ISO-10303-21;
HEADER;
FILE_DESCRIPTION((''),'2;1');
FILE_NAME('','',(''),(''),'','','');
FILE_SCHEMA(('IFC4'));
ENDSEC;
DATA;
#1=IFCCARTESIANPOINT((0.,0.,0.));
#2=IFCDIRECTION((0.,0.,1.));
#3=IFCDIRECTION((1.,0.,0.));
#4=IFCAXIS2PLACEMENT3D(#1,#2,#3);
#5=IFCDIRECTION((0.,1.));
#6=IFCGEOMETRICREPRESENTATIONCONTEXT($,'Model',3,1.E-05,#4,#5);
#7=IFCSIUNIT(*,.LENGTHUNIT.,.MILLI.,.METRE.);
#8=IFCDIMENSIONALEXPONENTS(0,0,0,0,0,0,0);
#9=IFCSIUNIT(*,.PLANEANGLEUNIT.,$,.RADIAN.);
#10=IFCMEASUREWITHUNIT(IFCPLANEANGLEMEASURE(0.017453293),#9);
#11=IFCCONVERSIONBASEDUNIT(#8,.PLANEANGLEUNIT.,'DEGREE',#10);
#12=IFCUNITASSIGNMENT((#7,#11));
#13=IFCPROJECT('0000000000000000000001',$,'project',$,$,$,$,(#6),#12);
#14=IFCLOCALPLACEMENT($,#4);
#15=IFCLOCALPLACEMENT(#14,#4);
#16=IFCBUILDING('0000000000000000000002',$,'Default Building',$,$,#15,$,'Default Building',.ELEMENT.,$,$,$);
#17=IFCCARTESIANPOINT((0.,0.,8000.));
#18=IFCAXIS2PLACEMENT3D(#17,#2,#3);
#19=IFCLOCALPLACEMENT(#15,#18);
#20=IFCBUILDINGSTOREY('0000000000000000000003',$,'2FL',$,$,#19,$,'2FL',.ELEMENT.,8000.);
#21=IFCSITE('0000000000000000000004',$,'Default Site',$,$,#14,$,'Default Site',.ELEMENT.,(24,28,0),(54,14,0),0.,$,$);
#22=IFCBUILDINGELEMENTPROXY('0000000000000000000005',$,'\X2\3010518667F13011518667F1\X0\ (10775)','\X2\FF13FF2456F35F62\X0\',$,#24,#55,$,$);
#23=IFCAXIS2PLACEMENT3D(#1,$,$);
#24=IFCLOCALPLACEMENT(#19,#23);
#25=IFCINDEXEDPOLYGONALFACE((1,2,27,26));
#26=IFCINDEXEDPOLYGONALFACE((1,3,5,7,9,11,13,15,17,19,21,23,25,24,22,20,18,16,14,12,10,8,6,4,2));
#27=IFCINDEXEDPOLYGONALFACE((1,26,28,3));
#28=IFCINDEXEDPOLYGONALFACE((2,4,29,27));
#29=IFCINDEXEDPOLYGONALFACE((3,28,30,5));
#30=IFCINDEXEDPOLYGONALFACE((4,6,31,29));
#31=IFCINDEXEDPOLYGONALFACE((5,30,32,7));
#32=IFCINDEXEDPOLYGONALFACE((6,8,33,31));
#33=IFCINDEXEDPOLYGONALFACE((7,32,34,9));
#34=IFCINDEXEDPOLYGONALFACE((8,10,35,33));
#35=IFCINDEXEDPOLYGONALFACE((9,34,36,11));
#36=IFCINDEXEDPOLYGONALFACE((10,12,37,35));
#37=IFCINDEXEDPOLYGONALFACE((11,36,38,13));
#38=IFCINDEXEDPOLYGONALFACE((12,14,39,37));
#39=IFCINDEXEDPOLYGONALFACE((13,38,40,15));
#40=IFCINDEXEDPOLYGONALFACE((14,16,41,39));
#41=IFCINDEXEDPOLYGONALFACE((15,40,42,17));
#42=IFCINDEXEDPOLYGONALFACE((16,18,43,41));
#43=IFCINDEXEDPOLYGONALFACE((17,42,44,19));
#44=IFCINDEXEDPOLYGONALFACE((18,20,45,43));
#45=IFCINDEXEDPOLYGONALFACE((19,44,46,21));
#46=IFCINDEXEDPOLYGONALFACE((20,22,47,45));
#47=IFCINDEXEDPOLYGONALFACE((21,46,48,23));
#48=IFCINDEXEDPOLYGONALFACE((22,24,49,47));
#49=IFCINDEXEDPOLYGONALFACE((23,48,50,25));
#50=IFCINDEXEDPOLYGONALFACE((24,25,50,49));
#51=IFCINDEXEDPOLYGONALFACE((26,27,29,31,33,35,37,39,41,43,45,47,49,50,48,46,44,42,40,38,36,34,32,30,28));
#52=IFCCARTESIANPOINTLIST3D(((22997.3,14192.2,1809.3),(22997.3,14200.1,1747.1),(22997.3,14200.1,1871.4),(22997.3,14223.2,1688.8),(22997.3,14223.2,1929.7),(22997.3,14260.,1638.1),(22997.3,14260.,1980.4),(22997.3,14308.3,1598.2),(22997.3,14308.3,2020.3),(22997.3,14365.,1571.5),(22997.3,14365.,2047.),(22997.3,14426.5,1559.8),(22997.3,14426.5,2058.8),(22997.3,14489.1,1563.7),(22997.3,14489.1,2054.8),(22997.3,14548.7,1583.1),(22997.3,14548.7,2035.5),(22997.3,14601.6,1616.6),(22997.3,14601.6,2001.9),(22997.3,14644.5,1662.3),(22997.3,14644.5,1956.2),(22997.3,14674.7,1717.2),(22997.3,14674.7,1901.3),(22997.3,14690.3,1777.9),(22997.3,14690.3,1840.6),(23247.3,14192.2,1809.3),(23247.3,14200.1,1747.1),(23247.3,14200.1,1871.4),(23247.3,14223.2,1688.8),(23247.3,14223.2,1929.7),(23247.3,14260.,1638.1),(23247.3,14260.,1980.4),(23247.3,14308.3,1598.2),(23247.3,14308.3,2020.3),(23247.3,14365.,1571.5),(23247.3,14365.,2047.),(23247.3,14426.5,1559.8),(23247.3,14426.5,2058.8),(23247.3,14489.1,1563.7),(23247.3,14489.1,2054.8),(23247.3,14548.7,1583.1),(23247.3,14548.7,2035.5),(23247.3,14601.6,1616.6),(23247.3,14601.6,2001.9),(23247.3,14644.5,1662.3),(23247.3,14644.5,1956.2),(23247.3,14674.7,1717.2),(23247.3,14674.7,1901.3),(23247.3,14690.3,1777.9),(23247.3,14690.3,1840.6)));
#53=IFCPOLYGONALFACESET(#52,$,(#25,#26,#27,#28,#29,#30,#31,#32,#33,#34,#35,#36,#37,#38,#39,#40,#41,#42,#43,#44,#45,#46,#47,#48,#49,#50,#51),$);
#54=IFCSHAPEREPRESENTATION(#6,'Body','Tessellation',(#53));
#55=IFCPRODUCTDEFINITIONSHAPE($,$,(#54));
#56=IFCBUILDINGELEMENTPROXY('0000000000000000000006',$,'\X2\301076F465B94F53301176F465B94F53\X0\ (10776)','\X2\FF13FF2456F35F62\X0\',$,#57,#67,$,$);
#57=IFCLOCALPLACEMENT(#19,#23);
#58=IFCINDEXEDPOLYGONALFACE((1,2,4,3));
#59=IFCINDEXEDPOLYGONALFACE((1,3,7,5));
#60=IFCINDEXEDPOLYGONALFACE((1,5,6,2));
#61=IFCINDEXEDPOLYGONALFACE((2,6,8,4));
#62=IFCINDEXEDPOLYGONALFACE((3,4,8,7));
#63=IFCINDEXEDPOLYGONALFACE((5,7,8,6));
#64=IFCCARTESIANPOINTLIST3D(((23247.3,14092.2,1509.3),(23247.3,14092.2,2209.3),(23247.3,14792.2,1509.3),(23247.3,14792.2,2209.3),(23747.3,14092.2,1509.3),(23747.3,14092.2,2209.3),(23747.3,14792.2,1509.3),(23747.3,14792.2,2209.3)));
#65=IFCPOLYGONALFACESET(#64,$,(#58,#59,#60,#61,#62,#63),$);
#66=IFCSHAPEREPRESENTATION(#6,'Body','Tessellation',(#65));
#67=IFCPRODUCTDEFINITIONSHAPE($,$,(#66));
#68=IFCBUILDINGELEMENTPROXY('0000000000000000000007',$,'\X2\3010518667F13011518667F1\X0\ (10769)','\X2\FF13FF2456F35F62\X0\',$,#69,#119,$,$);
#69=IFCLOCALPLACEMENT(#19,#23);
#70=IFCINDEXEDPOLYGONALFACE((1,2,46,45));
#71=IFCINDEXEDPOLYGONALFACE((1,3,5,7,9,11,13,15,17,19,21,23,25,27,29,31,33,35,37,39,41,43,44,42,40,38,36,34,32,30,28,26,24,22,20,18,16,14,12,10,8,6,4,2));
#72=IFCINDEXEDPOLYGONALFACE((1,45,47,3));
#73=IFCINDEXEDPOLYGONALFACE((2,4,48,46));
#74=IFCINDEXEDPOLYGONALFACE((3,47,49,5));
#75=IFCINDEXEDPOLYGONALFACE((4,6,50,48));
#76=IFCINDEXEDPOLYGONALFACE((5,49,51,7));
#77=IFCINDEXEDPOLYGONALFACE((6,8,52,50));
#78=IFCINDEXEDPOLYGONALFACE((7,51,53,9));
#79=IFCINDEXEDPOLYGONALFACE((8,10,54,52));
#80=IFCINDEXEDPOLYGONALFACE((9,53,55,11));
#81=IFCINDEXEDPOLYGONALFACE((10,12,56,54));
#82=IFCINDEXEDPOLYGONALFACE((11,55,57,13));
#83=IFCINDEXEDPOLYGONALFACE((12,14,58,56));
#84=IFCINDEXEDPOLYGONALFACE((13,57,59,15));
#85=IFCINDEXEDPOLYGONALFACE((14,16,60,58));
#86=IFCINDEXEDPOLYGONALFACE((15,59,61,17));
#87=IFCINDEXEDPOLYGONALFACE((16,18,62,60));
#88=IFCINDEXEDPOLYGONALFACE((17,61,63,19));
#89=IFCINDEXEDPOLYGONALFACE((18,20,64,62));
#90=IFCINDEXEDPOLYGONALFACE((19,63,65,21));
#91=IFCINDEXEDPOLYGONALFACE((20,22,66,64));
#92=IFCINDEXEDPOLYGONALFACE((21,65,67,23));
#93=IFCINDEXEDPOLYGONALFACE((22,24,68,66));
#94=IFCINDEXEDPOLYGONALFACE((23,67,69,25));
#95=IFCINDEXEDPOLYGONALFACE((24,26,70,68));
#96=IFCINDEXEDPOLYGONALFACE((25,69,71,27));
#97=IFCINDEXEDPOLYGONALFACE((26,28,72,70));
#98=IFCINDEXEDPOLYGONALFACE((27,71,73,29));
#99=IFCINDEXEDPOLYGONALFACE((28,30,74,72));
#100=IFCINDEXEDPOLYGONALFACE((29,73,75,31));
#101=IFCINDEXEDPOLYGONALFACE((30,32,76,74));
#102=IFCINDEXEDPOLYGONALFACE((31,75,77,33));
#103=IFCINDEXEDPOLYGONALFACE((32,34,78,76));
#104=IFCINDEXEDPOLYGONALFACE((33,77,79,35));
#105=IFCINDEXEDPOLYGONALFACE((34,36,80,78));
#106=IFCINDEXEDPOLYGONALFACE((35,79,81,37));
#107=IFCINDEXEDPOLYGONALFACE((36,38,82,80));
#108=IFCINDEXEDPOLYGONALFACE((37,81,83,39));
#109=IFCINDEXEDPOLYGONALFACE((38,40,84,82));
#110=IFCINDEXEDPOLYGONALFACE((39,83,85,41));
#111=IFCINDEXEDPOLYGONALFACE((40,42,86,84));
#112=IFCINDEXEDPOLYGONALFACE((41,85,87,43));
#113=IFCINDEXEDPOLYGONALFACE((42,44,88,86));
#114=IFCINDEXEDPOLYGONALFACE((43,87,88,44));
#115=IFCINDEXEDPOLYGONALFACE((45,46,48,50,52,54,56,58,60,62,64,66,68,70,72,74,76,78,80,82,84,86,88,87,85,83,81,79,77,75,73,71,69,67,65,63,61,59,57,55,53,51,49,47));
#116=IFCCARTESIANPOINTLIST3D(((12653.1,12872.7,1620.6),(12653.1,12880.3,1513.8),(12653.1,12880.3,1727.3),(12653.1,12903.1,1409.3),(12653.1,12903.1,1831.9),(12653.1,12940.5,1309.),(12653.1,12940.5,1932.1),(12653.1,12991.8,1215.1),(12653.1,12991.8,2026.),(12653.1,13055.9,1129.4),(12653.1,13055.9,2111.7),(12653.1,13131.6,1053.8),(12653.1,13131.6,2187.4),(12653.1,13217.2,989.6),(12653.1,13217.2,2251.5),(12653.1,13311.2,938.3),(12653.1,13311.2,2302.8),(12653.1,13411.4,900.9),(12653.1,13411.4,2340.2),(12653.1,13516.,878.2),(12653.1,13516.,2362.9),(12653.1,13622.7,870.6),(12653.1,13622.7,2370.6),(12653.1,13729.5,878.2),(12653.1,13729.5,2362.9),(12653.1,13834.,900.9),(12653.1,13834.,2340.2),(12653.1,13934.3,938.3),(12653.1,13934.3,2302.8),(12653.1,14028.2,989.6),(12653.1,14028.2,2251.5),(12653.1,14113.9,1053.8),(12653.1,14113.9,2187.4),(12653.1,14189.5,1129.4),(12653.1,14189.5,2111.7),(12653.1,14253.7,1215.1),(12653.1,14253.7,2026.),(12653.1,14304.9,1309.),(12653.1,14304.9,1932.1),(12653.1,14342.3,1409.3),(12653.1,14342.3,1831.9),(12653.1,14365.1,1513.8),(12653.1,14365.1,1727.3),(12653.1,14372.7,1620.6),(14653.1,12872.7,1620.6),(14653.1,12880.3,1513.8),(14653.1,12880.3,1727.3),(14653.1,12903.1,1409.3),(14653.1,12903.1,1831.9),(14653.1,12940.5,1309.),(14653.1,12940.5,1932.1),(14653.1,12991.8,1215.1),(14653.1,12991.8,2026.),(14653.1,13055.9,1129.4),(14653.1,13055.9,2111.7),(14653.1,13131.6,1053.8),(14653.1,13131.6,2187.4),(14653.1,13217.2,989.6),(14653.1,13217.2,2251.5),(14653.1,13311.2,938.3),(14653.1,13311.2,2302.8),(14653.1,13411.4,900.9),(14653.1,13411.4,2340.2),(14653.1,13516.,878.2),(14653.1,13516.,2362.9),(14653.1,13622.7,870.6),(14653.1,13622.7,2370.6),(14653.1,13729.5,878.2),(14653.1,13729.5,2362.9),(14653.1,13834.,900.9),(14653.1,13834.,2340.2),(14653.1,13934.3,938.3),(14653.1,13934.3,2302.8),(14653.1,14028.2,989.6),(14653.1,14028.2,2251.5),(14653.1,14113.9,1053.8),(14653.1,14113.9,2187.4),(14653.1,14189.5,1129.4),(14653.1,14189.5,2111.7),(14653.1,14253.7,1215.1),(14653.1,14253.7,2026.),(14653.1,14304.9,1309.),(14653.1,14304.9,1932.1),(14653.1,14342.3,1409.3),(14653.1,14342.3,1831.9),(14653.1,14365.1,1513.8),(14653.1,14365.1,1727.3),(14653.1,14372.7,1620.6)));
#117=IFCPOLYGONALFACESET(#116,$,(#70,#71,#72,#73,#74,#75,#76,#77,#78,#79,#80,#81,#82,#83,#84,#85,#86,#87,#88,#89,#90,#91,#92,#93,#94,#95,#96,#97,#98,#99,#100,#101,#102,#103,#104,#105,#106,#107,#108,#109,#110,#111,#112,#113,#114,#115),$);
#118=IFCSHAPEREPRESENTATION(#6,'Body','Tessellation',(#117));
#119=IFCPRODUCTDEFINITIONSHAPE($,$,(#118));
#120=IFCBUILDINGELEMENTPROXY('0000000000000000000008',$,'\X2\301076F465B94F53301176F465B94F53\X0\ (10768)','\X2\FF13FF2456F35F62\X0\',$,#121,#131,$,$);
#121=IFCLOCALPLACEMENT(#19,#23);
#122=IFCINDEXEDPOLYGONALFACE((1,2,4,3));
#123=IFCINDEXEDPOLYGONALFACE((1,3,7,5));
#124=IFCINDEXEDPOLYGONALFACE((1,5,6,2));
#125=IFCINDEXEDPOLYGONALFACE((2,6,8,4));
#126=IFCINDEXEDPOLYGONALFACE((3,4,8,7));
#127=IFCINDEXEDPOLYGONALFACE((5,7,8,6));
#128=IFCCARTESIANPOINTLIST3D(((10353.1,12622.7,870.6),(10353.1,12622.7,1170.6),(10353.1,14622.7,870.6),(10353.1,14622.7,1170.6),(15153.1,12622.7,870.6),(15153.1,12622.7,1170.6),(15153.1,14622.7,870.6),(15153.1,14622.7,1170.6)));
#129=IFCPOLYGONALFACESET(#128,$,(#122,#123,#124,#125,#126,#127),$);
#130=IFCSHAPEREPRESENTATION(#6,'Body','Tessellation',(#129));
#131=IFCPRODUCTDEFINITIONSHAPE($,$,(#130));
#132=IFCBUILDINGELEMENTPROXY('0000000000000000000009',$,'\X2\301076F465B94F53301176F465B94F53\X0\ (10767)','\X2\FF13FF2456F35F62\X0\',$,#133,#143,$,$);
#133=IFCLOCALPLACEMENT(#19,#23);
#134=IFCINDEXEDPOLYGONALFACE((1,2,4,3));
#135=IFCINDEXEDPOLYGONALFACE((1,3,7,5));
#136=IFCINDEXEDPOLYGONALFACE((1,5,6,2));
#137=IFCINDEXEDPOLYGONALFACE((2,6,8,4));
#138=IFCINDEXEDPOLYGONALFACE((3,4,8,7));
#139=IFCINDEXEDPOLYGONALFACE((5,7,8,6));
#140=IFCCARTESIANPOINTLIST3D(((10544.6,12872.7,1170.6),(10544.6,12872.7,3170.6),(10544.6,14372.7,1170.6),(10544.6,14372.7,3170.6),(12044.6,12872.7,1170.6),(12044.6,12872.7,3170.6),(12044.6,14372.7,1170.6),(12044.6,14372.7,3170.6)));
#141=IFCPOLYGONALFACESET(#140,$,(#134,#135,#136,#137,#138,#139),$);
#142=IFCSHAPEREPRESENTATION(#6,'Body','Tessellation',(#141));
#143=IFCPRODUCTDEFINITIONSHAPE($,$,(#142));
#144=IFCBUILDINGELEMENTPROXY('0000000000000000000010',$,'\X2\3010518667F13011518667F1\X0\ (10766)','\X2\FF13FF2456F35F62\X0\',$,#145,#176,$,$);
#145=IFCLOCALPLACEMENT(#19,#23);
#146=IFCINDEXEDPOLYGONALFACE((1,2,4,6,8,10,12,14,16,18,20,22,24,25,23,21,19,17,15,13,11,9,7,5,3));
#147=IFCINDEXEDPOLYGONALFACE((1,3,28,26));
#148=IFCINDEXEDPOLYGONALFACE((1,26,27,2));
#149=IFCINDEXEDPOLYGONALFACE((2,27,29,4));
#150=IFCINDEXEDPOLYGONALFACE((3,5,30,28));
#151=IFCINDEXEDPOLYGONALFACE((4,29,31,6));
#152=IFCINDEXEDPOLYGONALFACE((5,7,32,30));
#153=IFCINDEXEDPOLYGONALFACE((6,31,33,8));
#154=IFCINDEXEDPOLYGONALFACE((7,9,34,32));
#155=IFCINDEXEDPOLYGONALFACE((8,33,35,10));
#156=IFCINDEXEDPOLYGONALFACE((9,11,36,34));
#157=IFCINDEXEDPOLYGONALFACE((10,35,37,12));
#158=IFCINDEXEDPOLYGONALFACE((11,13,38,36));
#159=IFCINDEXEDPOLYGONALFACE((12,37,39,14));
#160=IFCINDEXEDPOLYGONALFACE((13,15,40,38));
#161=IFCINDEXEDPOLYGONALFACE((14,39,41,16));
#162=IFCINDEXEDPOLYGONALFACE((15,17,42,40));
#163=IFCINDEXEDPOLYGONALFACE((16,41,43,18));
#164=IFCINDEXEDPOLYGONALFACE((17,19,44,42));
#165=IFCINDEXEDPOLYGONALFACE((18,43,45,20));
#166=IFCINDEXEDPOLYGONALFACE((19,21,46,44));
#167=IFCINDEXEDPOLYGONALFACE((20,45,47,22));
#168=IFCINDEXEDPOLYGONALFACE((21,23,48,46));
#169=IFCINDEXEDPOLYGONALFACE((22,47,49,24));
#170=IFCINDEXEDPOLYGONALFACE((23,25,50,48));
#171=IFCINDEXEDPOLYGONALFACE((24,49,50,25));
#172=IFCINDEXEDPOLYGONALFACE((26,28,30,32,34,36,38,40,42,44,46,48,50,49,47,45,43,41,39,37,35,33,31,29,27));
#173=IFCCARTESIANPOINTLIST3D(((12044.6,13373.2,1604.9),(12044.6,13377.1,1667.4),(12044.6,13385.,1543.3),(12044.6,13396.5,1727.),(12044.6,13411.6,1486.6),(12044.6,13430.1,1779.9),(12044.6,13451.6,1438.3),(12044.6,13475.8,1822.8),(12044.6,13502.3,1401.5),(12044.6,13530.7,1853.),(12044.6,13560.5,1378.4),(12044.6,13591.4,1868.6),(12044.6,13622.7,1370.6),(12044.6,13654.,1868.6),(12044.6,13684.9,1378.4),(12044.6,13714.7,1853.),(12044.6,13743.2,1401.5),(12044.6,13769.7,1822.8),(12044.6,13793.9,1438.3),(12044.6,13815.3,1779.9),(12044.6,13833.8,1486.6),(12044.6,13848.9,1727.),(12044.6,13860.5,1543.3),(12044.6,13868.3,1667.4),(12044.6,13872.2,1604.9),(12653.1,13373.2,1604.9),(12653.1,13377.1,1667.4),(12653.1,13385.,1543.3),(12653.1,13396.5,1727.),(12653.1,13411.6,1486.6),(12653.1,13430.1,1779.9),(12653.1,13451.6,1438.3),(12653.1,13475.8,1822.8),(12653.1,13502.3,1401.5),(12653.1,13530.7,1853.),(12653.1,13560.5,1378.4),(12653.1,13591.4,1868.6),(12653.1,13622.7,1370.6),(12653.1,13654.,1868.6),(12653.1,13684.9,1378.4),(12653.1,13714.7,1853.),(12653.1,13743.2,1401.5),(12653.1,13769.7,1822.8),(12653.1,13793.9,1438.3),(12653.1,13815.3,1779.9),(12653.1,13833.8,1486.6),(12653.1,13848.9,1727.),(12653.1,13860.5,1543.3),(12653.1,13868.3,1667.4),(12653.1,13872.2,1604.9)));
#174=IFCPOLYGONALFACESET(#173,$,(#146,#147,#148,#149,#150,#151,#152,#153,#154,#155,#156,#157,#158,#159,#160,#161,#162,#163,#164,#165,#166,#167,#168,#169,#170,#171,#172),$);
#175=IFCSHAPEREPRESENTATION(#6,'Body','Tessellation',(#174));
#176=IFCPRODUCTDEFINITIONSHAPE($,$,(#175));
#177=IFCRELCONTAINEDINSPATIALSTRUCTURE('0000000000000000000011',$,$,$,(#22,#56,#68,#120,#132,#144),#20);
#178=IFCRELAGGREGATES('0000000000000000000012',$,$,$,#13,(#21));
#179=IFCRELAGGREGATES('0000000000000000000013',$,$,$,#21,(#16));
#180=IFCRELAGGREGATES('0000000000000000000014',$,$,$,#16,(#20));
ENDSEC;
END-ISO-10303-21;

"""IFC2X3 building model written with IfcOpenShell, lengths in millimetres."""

from ifc_helpers import new_model, entity, si_unit, converted_unit, direction, frame, origin_with_axes, origin_2d_with_axis, place, context, project, spatial, rectangle, circle, extrude, source, transform, mapped, element, save


model = new_model("IFC2X3")

# Units and contexts
model_context = context("Model", 3, precision=1e-05, world=origin_with_axes(), true_north=direction((0.0, 1.0)))
ifc_project = project(units=[si_unit("LENGTHUNIT", "METRE", prefix="MILLI"), converted_unit("PLANEANGLEUNIT", "DEGREE", entity("IfcPlaneAngleMeasure", 0.017453293), si_unit("PLANEANGLEUNIT", "RADIAN"), dimensions=[0, 0, 0, 0, 0, 0, 0])], contexts=[model_context])

# Site, building, storey
site_placement = place(None, origin_with_axes())
site = spatial("IfcSite", under=ifc_project, at=site_placement, Name="Default Site", LongName="Default Site", CompositionType="ELEMENT", RefLatitude=(24, 28, 0), RefLongitude=(54, 14, 0), RefElevation=0.0)
building_placement = place(site_placement, origin_with_axes())
building = spatial("IfcBuilding", under=site, at=building_placement, Name="Default Building", LongName="Default Building", CompositionType="ELEMENT")
storey_placement = place(building_placement, frame((0.0, 0.0, 8000.0), z_axis=(0.0, 0.0, 1.0), x_axis=(1.0, 0.0, 0.0)))
storey = spatial("IfcBuildingStorey", under=building, at=storey_placement, Name="2FL", LongName="2FL", CompositionType="ELEMENT", Elevation=8000.0)

# Building element proxies
shared_shape_1 = source(origin_with_axes(), model_context, "Body", "SweptSolid", [
    extrude(circle(Radius=250.0, at=origin_2d_with_axis()), frame((0.0, 0.0, 0.0), z_axis=(0.0, 0.0, 1.0), x_axis=(1.0, 0.0, 0.0)), (0.0, 0.0, 1.0), 250.0),
])
proxy_1_placement = place(storey_placement, frame((23247.3, 14442.2, 1809.3), z_axis=(-1.0, 0.0, 0.0), x_axis=(0.0, -1.0, 0.0)))
element("IfcBuildingElementProxy", 1, at=proxy_1_placement, inside=storey, Name="【円柱】円柱 (10775)", Description="３Ｄ図形", context=model_context, shape_type="MappedRepresentation", body=[
    mapped(shared_shape_1, transform((0.0, 0.0, 0.0))),
])
shared_shape_2 = source(origin_with_axes(), model_context, "Body", "SweptSolid", [
    extrude(rectangle(XDim=500.0, YDim=700.0, at=origin_2d_with_axis()), origin_with_axes(), (0.0, 0.0, 1.0), 700.0),
])
proxy_2_placement = place(storey_placement, frame((23497.3, 14442.2, 1509.3), z_axis=(0.0, 0.0, 1.0), x_axis=(1.0, 0.0, 0.0)))
element("IfcBuildingElementProxy", 2, at=proxy_2_placement, inside=storey, Name="【直方体】直方体 (10776)", Description="３Ｄ図形", context=model_context, shape_type="MappedRepresentation", body=[
    mapped(shared_shape_2, transform((0.0, 0.0, 0.0))),
])
shared_shape_3 = source(origin_with_axes(), model_context, "Body", "SweptSolid", [
    extrude(circle(Radius=750.0, at=origin_2d_with_axis()), frame((0.0, 0.0, 0.0), z_axis=(0.0, 0.0, 1.0), x_axis=(1.0, 0.0, 0.0)), (0.0, 0.0, 1.0), 2000.0),
])
proxy_3_placement = place(storey_placement, frame((14653.1, 13622.7, 1620.6), z_axis=(-1.0, 0.0, 0.0), x_axis=(0.0, 0.0, 1.0)))
element("IfcBuildingElementProxy", 3, at=proxy_3_placement, inside=storey, Name="【円柱】円柱 (10769)", Description="３Ｄ図形", context=model_context, shape_type="MappedRepresentation", body=[
    mapped(shared_shape_3, transform((0.0, 0.0, 0.0))),
])
shared_shape_4 = source(origin_with_axes(), model_context, "Body", "SweptSolid", [
    extrude(rectangle(XDim=4800.0, YDim=2000.0, at=origin_2d_with_axis()), origin_with_axes(), (0.0, 0.0, 1.0), 300.0),
])
proxy_4_placement = place(storey_placement, frame((12753.1, 13622.7, 870.6), z_axis=(0.0, 0.0, 1.0), x_axis=(1.0, 0.0, 0.0)))
element("IfcBuildingElementProxy", 4, at=proxy_4_placement, inside=storey, Name="【直方体】直方体 (10768)", Description="３Ｄ図形", context=model_context, shape_type="MappedRepresentation", body=[
    mapped(shared_shape_4, transform((0.0, 0.0, 0.0))),
])
shared_shape_5 = source(origin_with_axes(), model_context, "Body", "SweptSolid", [
    extrude(rectangle(XDim=1500.0, YDim=1500.0, at=origin_2d_with_axis()), origin_with_axes(), (0.0, 0.0, 1.0), 2000.0),
])
proxy_5_placement = place(storey_placement, frame((11294.6, 13622.7, 1170.6), z_axis=(0.0, 0.0, 1.0), x_axis=(1.0, 0.0, 0.0)))
element("IfcBuildingElementProxy", 5, at=proxy_5_placement, inside=storey, Name="【直方体】直方体 (10767)", Description="３Ｄ図形", context=model_context, shape_type="MappedRepresentation", body=[
    mapped(shared_shape_5, transform((0.0, 0.0, 0.0))),
])
shared_shape_6 = source(origin_with_axes(), model_context, "Body", "SweptSolid", [
    extrude(circle(Radius=250.0, at=origin_2d_with_axis()), frame((0.0, 0.0, 0.0), z_axis=(0.0, 0.0, 1.0), x_axis=(1.0, 0.0, 0.0)), (0.0, 0.0, 1.0), 608.5),
])
proxy_6_placement = place(storey_placement, frame((12044.6, 13622.7, 1620.6), z_axis=(1.0, 0.0, 0.0), x_axis=(0.0, 0.0, -1.0)))
element("IfcBuildingElementProxy", 6, at=proxy_6_placement, inside=storey, Name="【円柱】円柱 (10766)", Description="３Ｄ図形", context=model_context, shape_type="MappedRepresentation", body=[
    mapped(shared_shape_6, transform((0.0, 0.0, 0.0))),
])

save(model, "model.ifc")
